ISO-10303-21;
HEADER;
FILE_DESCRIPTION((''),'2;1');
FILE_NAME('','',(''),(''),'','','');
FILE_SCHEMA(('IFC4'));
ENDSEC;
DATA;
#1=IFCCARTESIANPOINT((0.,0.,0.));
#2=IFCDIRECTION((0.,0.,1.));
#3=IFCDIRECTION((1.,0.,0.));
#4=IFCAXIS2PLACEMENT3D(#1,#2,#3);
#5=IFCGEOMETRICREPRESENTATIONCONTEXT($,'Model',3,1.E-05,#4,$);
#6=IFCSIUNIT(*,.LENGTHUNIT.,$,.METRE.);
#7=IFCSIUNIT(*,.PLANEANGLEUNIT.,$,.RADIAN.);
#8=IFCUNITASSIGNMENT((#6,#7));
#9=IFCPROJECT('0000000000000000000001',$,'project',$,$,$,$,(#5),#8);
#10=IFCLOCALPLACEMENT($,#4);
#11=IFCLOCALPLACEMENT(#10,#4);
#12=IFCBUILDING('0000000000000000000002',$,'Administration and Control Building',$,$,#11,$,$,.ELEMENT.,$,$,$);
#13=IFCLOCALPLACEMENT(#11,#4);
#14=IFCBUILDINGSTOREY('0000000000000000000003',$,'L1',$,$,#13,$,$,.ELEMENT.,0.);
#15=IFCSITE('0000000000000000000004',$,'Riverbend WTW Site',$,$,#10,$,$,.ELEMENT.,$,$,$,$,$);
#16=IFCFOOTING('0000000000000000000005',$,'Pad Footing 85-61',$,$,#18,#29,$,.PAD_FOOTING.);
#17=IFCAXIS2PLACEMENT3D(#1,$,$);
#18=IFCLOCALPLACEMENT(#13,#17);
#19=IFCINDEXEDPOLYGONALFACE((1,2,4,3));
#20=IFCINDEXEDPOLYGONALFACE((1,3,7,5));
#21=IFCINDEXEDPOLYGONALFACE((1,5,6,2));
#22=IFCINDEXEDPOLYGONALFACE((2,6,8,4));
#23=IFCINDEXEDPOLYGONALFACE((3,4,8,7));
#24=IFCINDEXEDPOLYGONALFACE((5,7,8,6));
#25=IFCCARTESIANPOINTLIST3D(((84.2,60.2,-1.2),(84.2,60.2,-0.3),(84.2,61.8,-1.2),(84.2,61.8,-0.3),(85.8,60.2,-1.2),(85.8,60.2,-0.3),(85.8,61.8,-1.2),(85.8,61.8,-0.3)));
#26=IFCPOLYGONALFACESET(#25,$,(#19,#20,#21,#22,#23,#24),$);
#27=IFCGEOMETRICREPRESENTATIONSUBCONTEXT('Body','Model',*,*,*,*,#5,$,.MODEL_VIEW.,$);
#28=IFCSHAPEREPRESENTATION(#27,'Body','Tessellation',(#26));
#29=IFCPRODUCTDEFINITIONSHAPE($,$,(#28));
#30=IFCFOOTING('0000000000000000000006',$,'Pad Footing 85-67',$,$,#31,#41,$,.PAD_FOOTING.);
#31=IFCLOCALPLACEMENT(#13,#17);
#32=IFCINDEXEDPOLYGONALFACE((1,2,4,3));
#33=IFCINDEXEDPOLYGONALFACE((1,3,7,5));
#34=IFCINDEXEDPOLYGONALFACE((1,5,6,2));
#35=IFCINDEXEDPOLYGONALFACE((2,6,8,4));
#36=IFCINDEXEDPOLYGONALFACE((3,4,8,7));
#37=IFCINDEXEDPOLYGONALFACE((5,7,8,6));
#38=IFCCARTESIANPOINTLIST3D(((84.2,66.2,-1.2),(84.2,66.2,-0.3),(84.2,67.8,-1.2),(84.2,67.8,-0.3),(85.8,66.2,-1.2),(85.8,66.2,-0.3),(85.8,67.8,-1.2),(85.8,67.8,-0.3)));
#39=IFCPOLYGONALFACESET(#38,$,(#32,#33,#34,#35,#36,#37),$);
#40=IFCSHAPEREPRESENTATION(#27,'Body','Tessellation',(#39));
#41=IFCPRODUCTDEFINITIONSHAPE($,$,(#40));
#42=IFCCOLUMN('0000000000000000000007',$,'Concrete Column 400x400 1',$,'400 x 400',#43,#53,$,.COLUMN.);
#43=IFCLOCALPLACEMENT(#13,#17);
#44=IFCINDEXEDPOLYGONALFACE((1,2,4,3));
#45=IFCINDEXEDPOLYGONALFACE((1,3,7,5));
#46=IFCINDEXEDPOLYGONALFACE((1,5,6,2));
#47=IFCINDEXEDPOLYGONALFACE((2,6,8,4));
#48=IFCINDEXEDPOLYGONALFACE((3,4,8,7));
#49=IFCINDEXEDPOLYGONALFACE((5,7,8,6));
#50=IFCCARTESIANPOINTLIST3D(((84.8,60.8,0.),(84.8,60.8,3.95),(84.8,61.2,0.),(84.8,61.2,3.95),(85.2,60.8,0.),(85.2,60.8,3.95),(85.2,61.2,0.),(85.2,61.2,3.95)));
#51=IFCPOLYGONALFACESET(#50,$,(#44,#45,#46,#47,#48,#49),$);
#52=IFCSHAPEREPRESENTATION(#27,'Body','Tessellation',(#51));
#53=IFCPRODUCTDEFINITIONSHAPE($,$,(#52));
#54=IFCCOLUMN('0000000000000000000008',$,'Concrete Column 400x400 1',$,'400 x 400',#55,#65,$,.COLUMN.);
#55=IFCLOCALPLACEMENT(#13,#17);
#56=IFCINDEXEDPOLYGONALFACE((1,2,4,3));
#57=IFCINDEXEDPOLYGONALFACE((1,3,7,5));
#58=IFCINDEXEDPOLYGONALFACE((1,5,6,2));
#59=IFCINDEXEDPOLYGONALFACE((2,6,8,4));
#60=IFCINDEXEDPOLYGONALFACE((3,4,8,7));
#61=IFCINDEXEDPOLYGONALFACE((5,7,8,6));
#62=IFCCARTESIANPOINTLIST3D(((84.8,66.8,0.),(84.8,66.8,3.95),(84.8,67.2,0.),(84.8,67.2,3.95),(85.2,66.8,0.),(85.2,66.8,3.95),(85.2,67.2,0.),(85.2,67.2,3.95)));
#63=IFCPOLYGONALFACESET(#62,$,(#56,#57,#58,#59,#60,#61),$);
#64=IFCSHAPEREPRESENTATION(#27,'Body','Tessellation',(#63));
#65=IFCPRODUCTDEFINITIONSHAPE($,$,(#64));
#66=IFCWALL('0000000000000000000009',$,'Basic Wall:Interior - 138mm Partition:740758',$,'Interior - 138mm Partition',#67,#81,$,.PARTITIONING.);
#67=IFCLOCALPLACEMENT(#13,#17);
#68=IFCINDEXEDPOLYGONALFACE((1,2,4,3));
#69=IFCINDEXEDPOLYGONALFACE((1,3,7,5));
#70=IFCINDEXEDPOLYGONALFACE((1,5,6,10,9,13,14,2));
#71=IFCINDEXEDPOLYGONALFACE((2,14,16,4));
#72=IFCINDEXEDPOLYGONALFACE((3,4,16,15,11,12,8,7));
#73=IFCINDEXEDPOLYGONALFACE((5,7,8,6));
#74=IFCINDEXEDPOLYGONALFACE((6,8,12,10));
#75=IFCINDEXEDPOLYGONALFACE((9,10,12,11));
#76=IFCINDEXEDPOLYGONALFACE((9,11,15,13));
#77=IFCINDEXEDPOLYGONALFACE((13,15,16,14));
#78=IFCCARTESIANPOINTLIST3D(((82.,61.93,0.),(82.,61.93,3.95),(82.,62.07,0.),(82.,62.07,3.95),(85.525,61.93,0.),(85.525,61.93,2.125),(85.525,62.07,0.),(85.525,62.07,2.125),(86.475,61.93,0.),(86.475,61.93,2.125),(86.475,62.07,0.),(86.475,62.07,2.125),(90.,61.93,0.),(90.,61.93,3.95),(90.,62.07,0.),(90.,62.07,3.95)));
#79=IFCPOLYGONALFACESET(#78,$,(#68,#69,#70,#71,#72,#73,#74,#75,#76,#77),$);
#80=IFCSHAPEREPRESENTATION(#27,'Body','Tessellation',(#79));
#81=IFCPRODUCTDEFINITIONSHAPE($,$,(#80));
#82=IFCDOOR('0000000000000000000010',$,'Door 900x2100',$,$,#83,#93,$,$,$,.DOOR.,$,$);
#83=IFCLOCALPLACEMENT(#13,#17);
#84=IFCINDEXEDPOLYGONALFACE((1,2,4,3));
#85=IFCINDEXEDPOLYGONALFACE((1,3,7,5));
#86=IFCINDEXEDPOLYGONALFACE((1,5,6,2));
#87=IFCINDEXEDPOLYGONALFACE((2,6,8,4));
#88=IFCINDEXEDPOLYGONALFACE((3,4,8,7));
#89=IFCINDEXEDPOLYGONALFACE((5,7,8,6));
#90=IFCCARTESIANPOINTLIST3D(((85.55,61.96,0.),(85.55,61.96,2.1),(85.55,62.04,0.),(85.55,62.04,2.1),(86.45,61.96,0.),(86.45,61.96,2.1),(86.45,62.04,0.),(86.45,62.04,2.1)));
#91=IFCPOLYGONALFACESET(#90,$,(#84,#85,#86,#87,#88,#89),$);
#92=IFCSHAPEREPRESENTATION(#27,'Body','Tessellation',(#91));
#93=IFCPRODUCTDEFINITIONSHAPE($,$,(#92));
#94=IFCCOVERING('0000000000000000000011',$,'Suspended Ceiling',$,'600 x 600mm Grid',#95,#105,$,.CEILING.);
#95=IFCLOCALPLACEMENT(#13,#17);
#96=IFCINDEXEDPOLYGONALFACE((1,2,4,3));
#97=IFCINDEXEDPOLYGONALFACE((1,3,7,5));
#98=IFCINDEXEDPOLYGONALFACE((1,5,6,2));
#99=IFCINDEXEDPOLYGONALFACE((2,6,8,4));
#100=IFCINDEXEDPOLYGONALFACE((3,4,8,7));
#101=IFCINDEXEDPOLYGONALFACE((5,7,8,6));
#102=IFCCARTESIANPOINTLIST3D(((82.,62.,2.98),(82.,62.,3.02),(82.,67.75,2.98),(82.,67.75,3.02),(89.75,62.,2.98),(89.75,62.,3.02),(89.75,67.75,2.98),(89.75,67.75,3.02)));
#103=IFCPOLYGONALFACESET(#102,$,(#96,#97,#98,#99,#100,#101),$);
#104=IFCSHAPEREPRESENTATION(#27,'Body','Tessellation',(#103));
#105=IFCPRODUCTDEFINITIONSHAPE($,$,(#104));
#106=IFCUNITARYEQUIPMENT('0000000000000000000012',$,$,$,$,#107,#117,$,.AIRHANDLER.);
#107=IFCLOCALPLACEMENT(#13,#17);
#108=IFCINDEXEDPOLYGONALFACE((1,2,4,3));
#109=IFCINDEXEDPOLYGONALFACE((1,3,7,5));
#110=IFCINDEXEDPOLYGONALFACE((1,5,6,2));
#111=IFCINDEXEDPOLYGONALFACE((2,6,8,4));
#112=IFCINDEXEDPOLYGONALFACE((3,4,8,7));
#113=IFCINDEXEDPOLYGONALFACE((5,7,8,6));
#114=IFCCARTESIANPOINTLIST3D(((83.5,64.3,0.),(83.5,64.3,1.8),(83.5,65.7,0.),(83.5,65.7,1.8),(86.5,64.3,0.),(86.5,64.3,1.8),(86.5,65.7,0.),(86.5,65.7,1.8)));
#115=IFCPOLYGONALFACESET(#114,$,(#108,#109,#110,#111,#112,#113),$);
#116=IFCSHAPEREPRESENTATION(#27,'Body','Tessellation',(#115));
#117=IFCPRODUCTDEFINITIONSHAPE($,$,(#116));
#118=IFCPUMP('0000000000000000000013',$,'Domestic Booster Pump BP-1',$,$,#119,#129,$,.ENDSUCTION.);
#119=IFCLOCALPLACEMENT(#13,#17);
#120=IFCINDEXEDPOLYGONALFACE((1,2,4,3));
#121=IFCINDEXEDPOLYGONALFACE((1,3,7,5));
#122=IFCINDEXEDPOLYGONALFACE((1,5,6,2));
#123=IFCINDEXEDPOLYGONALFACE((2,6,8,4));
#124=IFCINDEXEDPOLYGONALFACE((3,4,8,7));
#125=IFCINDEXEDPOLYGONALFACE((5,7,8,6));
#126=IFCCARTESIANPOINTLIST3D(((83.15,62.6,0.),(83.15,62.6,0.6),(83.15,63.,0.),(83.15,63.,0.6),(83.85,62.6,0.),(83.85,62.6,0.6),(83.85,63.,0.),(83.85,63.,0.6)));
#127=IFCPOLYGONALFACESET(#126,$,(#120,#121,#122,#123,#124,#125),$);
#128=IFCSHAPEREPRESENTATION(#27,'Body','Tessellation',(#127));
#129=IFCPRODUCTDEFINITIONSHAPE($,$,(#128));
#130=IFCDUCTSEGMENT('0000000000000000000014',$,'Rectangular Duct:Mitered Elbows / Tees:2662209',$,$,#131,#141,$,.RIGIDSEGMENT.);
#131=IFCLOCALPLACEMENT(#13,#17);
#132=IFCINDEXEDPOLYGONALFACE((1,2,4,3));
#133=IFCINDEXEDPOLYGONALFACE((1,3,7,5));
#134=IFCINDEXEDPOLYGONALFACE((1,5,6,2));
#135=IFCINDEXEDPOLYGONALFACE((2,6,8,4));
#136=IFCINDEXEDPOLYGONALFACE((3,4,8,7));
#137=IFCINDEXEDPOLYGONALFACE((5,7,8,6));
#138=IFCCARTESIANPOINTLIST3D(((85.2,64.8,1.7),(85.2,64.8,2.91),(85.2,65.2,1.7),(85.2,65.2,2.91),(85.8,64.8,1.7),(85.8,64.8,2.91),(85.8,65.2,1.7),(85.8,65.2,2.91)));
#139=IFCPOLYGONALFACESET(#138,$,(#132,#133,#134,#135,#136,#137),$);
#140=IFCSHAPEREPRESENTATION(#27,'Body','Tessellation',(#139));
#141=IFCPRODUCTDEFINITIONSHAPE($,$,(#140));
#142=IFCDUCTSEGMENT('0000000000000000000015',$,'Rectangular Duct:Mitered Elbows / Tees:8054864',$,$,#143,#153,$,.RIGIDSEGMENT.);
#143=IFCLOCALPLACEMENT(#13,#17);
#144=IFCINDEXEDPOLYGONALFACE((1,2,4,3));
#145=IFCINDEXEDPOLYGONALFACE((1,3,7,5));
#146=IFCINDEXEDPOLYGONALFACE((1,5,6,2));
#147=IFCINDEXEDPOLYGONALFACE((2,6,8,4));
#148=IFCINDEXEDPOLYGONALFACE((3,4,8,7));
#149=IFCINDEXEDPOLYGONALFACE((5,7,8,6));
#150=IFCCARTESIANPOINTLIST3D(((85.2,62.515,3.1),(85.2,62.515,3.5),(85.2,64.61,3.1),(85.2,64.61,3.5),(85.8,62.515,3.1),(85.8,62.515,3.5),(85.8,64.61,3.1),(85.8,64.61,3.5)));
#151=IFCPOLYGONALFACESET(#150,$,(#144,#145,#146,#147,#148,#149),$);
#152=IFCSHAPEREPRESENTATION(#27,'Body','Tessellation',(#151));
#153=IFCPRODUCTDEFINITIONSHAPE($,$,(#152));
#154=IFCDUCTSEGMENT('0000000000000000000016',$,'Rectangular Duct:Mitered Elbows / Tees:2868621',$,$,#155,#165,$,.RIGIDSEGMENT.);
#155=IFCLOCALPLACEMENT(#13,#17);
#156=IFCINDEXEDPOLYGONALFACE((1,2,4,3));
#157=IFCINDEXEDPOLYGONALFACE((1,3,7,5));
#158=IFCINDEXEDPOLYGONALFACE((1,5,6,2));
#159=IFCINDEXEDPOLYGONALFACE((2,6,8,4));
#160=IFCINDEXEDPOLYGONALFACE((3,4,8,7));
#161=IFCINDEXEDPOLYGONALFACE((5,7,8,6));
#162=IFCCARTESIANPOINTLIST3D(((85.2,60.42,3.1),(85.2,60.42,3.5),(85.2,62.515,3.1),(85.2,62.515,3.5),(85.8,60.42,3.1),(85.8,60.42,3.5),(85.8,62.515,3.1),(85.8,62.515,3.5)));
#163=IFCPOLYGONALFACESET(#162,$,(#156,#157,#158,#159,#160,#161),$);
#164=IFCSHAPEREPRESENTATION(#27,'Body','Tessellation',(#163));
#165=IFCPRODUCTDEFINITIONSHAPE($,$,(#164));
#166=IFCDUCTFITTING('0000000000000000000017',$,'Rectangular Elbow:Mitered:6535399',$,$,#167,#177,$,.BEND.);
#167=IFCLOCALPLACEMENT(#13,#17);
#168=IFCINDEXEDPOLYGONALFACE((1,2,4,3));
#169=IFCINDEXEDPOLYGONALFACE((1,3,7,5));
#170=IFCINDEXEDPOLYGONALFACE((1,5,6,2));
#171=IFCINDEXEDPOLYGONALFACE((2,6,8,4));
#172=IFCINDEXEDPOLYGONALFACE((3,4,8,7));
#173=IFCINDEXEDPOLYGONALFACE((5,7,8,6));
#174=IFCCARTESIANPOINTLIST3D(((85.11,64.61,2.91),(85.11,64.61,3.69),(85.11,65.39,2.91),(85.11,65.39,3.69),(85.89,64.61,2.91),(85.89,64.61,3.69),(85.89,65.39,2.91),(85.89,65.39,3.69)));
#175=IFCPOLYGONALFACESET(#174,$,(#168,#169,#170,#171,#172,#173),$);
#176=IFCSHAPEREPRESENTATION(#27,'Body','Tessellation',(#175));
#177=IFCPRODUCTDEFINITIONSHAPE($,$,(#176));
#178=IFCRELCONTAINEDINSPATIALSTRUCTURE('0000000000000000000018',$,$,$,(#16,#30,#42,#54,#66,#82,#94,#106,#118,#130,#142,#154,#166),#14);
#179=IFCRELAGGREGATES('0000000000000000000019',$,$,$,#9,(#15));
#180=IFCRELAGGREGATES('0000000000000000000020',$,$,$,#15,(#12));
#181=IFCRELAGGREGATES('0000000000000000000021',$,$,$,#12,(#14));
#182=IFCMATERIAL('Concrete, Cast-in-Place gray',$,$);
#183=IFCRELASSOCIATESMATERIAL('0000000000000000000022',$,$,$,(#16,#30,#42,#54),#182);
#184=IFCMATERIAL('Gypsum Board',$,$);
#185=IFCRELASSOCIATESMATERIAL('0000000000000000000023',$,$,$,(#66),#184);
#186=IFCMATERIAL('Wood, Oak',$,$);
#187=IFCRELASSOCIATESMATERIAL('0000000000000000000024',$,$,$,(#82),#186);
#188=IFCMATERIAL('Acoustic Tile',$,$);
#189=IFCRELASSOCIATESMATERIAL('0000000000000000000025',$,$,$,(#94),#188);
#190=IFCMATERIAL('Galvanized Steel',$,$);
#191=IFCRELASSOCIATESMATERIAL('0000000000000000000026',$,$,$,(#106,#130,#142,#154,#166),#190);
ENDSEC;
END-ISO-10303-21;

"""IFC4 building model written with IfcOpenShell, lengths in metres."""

from ifc_helpers import new_model, si_unit, frame, origin_with_axes, origin_2d, place, context, subcontext, project, spatial, rectangle, extrude, material, element, fill, save


model = new_model("IFC4")

# Units and contexts
model_context = context("Model", 3, precision=1e-05, world=origin_with_axes())
body_context = subcontext(model_context, "Body", "Model", "MODEL_VIEW")
ifc_project = project(units=[si_unit("LENGTHUNIT", "METRE"), si_unit("PLANEANGLEUNIT", "RADIAN")], contexts=[model_context])

# Site, building, storey
site_placement = place(None, origin_with_axes())
site = spatial("IfcSite", under=ifc_project, at=site_placement, Name="Riverbend WTW Site", CompositionType="ELEMENT")
building_placement = place(site_placement, origin_with_axes())
building = spatial("IfcBuilding", under=site, at=building_placement, Name="Administration and Control Building", CompositionType="ELEMENT")
storey_placement = place(building_placement, origin_with_axes())
storey = spatial("IfcBuildingStorey", under=building, at=storey_placement, Name="L1", CompositionType="ELEMENT", Elevation=0.0)

# Footings
ifc_material_1 = material(Name="Concrete, Cast-in-Place gray")
for number, where, z_axis, x_axis, name in (
    (1, (85.0, 61.0, -0.75), (0.0, 0.0, 1.0), (1.0, 0.0, 0.0), "Pad Footing 85-61"),
    (2, (85.0, 67.0, -0.75), (0.0, 0.0, 1.0), (1.0, 0.0, 0.0), "Pad Footing 85-67"),
):
    element("IfcFooting", number, at=place(None, frame(where, z_axis=z_axis, x_axis=x_axis)), inside=storey, material=ifc_material_1, Name=name, PredefinedType="PAD_FOOTING", context=body_context, shape_type="SweptSolid", body=[
        extrude(rectangle(XDim=1.6, YDim=1.6, at=origin_2d()), frame((0.0, 0.0, -0.45), z_axis=(0.0, 0.0, 1.0), x_axis=(1.0, 0.0, 0.0)), (0.0, 0.0, 1.0), 0.9),
    ])

# Columns
for number, where, z_axis, x_axis, name in (
    (3, (85.0, 61.0, 1.975), (0.0, 0.0, 1.0), (1.0, 0.0, 0.0), "Concrete Column 400x400 1"),
    (4, (85.0, 67.0, 1.975), (0.0, 0.0, 1.0), (1.0, 0.0, 0.0), "Concrete Column 400x400 1"),
):
    element("IfcColumn", number, at=place(None, frame(where, z_axis=z_axis, x_axis=x_axis)), inside=storey, material=ifc_material_1, Name=name, ObjectType="400 x 400", PredefinedType="COLUMN", context=body_context, shape_type="SweptSolid", body=[
        extrude(rectangle(XDim=0.4, YDim=0.4, at=origin_2d()), frame((0.0, 0.0, -1.975), z_axis=(0.0, 0.0, 1.0), x_axis=(1.0, 0.0, 0.0)), (0.0, 0.0, 1.0), 3.95),
    ])

# Wall, opening, door
ifc_material_2 = material(Name="Gypsum Board")
wall_placement = place(None, frame((86.0, 62.0, 1.975), z_axis=(0.0, 0.0, 1.0), x_axis=(1.0, 0.0, 0.0)))
wall = element("IfcWall", 5, at=wall_placement, inside=storey, material=ifc_material_2, Name="Basic Wall:Interior - 138mm Partition:740758", ObjectType="Interior - 138mm Partition", PredefinedType="PARTITIONING", context=body_context, shape_type="SweptSolid", body=[
    extrude(rectangle(XDim=8.0, YDim=0.14, at=origin_2d()), frame((0.0, 0.0, -1.975), z_axis=(0.0, 0.0, 1.0), x_axis=(1.0, 0.0, 0.0)), (0.0, 0.0, 1.0), 3.95),
])
opening_placement = place(None, frame((86.0, 62.0, 1.05), z_axis=(0.0, 0.0, 1.0), x_axis=(1.0, 0.0, 0.0)))
opening = element("IfcOpeningElement", 6, at=opening_placement, inside=storey, cuts=wall, context=body_context, shape_type="SweptSolid", body=[
    extrude(rectangle(XDim=0.95, YDim=0.4, at=origin_2d()), frame((0.0, 0.0, -1.075), z_axis=(0.0, 0.0, 1.0), x_axis=(1.0, 0.0, 0.0)), (0.0, 0.0, 1.0), 2.15),
])
ifc_material_3 = material(Name="Wood, Oak")
door_placement = place(None, frame((86.0, 62.0, 1.05), z_axis=(0.0, 0.0, 1.0), x_axis=(1.0, 0.0, 0.0)))
door = element("IfcDoor", 7, at=door_placement, inside=storey, material=ifc_material_3, Name="Door 900x2100", PredefinedType="DOOR", context=body_context, shape_type="SweptSolid", body=[
    extrude(rectangle(XDim=0.9, YDim=0.08, at=origin_2d()), frame((0.0, 0.0, -1.05), z_axis=(0.0, 0.0, 1.0), x_axis=(1.0, 0.0, 0.0)), (0.0, 0.0, 1.0), 2.1),
])
fill(opening, door)

# Covering
ifc_material_4 = material(Name="Acoustic Tile")
covering_placement = place(None, frame((85.875, 64.875, 3.0), z_axis=(0.0, 0.0, 1.0), x_axis=(1.0, 0.0, 0.0)))
element("IfcCovering", 8, at=covering_placement, inside=storey, material=ifc_material_4, Name="Suspended Ceiling", ObjectType="600 x 600mm Grid", PredefinedType="CEILING", context=body_context, shape_type="SweptSolid", body=[
    extrude(rectangle(XDim=7.75, YDim=5.75, at=origin_2d()), frame((0.0, 0.0, -0.02), z_axis=(0.0, 0.0, 1.0), x_axis=(1.0, 0.0, 0.0)), (0.0, 0.0, 1.0), 0.04),
])

# Unitary equipment
ifc_material_5 = material(Name="Galvanized Steel")
unitary_equipment_placement = place(None, frame((85.0, 65.0, 0.9), z_axis=(0.0, 0.0, 1.0), x_axis=(1.0, 0.0, 0.0)))
element("IfcUnitaryEquipment", 9, at=unitary_equipment_placement, inside=storey, material=ifc_material_5, PredefinedType="AIRHANDLER", context=body_context, shape_type="SweptSolid", body=[
    extrude(rectangle(XDim=3.0, YDim=1.4, at=origin_2d()), frame((0.0, 0.0, -0.9), z_axis=(0.0, 0.0, 1.0), x_axis=(1.0, 0.0, 0.0)), (0.0, 0.0, 1.0), 1.8),
])

# Pump
pump_placement = place(None, frame((83.5, 62.8, 0.3), z_axis=(0.0, 0.0, 1.0), x_axis=(1.0, 0.0, 0.0)))
element("IfcPump", 10, at=pump_placement, inside=storey, Name="Domestic Booster Pump BP-1", PredefinedType="ENDSUCTION", context=body_context, shape_type="SweptSolid", body=[
    extrude(rectangle(XDim=0.7, YDim=0.4, at=origin_2d()), frame((0.0, 0.0, -0.3), z_axis=(0.0, 0.0, 1.0), x_axis=(1.0, 0.0, 0.0)), (0.0, 0.0, 1.0), 0.6),
])

# Duct segments
duct_segment_placement = place(None, frame((85.5, 65.0, 2.305), z_axis=(0.0, 0.0, 1.0), x_axis=(1.0, 0.0, 0.0)))
element("IfcDuctSegment", 11, at=duct_segment_placement, inside=storey, material=ifc_material_5, Name="Rectangular Duct:Mitered Elbows / Tees:2662209", PredefinedType="RIGIDSEGMENT", context=body_context, shape_type="SweptSolid", body=[
    extrude(rectangle(XDim=0.6, YDim=0.4, at=origin_2d()), frame((0.0, 0.0, -0.605), z_axis=(0.0, 0.0, 1.0), x_axis=(1.0, 0.0, 0.0)), (0.0, 0.0, 1.0), 1.21),
])
for number, where, z_axis, x_axis, name in (
    (12, (85.5, 63.5625, 3.3), (0.0, 0.0, 1.0), (1.0, 0.0, 0.0), "Rectangular Duct:Mitered Elbows / Tees:8054864"),
    (13, (85.5, 61.4675, 3.3), (0.0, 0.0, 1.0), (1.0, 0.0, 0.0), "Rectangular Duct:Mitered Elbows / Tees:2868621"),
):
    element("IfcDuctSegment", number, at=place(None, frame(where, z_axis=z_axis, x_axis=x_axis)), inside=storey, material=ifc_material_5, Name=name, PredefinedType="RIGIDSEGMENT", context=body_context, shape_type="SweptSolid", body=[
        extrude(rectangle(XDim=0.6, YDim=2.095, at=origin_2d()), frame((0.0, 0.0, -0.2), z_axis=(0.0, 0.0, 1.0), x_axis=(1.0, 0.0, 0.0)), (0.0, 0.0, 1.0), 0.4),
    ])

# Duct fitting
duct_fitting_placement = place(None, frame((85.5, 65.0, 3.3), z_axis=(0.0, 0.0, 1.0), x_axis=(1.0, 0.0, 0.0)))
element("IfcDuctFitting", 14, at=duct_fitting_placement, inside=storey, material=ifc_material_5, Name="Rectangular Elbow:Mitered:6535399", PredefinedType="BEND", context=body_context, shape_type="SweptSolid", body=[
    extrude(rectangle(XDim=0.78, YDim=0.78, at=origin_2d()), frame((0.0, 0.0, -0.39), z_axis=(0.0, 0.0, 1.0), x_axis=(1.0, 0.0, 0.0)), (0.0, 0.0, 1.0), 0.78),
])

save(model, "model.ifc")
